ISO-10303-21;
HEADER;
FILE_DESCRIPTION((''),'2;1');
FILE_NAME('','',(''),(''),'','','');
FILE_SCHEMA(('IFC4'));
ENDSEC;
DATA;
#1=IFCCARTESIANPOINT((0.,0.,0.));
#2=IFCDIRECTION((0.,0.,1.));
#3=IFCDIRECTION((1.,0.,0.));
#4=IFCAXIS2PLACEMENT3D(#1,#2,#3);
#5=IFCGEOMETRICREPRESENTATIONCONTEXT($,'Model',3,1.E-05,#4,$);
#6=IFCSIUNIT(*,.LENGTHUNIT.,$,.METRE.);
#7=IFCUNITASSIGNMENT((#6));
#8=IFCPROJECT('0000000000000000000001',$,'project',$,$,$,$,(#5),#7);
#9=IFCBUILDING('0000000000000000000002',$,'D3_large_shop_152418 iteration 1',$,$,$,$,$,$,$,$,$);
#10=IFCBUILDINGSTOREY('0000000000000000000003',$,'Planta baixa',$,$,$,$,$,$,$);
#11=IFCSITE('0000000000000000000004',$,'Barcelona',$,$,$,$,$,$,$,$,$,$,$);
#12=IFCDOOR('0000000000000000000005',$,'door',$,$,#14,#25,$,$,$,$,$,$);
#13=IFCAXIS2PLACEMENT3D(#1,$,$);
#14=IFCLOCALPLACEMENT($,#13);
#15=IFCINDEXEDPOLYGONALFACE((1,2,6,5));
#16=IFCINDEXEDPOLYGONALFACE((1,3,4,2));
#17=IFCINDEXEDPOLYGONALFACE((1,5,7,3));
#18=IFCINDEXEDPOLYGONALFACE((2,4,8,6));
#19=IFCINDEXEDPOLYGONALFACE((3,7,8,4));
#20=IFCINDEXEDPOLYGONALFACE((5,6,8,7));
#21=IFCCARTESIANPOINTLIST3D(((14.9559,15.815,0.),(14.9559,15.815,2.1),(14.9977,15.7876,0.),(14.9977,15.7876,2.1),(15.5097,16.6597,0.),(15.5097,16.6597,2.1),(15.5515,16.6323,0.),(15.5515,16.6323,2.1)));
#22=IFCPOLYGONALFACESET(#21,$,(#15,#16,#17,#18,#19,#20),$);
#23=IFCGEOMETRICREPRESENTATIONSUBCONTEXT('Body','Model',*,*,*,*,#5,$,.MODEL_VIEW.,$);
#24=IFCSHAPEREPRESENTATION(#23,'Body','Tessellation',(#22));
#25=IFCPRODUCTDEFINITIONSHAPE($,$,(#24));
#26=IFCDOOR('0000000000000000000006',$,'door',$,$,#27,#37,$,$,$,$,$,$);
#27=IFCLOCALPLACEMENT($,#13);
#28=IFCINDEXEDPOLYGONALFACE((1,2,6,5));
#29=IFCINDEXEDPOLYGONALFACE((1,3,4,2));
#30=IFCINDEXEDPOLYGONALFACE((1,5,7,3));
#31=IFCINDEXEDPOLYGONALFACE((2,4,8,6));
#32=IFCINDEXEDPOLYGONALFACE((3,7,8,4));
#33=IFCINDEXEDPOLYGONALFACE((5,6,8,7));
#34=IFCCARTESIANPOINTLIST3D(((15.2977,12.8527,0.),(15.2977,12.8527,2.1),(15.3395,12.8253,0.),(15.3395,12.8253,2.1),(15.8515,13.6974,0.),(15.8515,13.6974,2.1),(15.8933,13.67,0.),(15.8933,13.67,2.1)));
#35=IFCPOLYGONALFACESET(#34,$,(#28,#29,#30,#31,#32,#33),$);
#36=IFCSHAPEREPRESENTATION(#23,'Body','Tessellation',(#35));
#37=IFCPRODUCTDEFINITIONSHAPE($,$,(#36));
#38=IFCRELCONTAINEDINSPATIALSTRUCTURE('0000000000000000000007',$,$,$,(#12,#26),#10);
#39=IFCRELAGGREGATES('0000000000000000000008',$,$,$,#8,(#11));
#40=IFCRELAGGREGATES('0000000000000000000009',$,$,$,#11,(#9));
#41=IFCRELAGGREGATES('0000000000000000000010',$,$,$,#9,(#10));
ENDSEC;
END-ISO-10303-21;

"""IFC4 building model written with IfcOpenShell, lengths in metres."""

from ifc_helpers import new_model, si_unit, origin, origin_with_axes, place, context, subcontext, project, spatial, polyline, outline, extrude, element, save


model = new_model("IFC4")

# Units and contexts
model_context = context("Model", 3, precision=1e-05, world=origin_with_axes())
body_context = subcontext(model_context, "Body", "Model", "MODEL_VIEW")
ifc_project = project(units=[si_unit("LENGTHUNIT", "METRE")], contexts=[model_context])

# Site, building, storey
site = spatial("IfcSite", under=ifc_project, Name="Barcelona")
building = spatial("IfcBuilding", under=site, Name="D3_large_shop_152418 iteration 1")
storey = spatial("IfcBuildingStorey", under=building, Name="Planta baixa")

# Doors
door_1_placement = place(None, origin_with_axes())
element("IfcDoor", 1, at=door_1_placement, inside=storey, Name="door", context=body_context, shape_type="SweptSolid", body=[
    extrude(outline(polyline([(14.9559, 15.815), (15.5097, 16.6597), (15.5515, 16.6323), (14.9977, 15.7876), (14.9559, 15.815)])), origin(), (0.0, 0.0, 1.0), 2.1),
])
door_2_placement = place(None, origin_with_axes())
element("IfcDoor", 2, at=door_2_placement, inside=storey, Name="door", context=body_context, shape_type="SweptSolid", body=[
    extrude(outline(polyline([(15.2977, 12.8527), (15.8515, 13.6974), (15.8933, 13.67), (15.3395, 12.8253), (15.2977, 12.8527)])), origin(), (0.0, 0.0, 1.0), 2.1),
])

save(model, "model.ifc")
